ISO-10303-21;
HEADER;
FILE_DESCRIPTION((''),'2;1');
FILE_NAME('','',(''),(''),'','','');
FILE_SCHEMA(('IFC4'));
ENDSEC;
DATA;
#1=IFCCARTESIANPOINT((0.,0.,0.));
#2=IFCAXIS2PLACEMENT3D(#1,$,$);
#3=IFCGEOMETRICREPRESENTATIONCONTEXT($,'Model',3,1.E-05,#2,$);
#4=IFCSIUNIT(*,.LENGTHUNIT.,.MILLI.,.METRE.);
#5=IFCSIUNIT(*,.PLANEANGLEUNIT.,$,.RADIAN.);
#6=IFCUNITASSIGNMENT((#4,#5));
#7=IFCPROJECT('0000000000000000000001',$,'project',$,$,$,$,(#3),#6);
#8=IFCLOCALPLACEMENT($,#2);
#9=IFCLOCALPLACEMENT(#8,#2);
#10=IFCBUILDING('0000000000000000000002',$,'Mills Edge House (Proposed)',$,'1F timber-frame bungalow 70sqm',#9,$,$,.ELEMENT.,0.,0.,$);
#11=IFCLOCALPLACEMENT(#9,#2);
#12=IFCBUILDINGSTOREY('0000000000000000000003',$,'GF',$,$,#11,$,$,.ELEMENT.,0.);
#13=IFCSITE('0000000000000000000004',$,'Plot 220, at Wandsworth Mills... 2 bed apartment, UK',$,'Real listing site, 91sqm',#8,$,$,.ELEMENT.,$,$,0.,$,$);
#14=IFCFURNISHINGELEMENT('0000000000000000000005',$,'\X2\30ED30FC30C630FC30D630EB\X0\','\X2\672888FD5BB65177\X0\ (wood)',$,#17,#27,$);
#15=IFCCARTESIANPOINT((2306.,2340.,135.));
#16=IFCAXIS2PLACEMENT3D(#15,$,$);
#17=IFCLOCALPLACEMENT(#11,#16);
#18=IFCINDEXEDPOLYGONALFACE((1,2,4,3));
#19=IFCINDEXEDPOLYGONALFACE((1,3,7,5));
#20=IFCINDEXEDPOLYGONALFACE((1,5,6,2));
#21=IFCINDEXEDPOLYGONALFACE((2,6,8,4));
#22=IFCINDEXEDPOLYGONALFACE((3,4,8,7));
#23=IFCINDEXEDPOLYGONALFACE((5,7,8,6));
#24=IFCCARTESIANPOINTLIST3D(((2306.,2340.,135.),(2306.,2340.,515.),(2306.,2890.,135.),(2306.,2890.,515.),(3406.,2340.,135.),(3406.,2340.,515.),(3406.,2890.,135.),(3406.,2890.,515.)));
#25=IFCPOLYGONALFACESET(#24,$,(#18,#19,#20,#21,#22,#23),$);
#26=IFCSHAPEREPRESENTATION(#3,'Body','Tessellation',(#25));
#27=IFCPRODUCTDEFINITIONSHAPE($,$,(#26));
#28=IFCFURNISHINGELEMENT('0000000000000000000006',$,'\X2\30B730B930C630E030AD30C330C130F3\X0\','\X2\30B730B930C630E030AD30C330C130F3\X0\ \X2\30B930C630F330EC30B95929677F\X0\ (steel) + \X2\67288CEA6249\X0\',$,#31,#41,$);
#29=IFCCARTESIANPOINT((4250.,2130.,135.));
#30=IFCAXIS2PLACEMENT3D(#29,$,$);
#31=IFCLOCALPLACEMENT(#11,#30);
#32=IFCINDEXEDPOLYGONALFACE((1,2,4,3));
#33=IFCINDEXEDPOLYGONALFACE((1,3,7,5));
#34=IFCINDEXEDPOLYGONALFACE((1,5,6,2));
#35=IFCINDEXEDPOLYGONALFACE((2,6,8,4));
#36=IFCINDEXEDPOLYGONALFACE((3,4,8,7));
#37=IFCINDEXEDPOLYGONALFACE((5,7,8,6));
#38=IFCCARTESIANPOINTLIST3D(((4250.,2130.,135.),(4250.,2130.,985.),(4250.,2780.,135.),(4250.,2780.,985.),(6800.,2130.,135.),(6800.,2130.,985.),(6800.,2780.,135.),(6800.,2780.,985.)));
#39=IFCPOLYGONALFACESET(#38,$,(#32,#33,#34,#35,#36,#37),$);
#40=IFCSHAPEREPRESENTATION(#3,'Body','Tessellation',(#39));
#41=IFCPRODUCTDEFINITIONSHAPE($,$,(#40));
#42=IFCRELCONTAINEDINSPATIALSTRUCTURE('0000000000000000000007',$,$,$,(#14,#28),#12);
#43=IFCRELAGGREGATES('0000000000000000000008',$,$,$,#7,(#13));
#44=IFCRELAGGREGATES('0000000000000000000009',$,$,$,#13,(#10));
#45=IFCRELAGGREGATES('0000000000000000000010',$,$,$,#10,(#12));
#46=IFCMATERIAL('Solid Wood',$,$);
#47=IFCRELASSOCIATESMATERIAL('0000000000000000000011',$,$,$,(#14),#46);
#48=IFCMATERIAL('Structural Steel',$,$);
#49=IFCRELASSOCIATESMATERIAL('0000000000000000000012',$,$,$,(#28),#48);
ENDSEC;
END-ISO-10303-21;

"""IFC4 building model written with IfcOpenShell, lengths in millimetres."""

from ifc_helpers import new_model, si_unit, frame, frame_2d, origin, place, context, project, spatial, rectangle, extrude, material, element, save


model = new_model("IFC4")

# Units and contexts
model_context = context("Model", 3, precision=1e-05, world=origin())
ifc_project = project(units=[si_unit("LENGTHUNIT", "METRE", prefix="MILLI"), si_unit("PLANEANGLEUNIT", "RADIAN")], contexts=[model_context])

# Site, building, storey
site_placement = place(None, origin())
site = spatial("IfcSite", under=ifc_project, at=site_placement, Name="Plot 220, at Wandsworth Mills... 2 bed apartment, UK", ObjectType="Real listing site, 91sqm", CompositionType="ELEMENT", RefElevation=0.0)
building_placement = place(site_placement, origin())
building = spatial("IfcBuilding", under=site, at=building_placement, Name="Mills Edge House (Proposed)", ObjectType="1F timber-frame bungalow 70sqm", CompositionType="ELEMENT", ElevationOfRefHeight=0.0, ElevationOfTerrain=0.0)
storey_placement = place(building_placement, origin())
storey = spatial("IfcBuildingStorey", under=building, at=storey_placement, Name="GF", CompositionType="ELEMENT", Elevation=0.0)

# Shared definitions
ifc_material_1 = material(Name="Solid Wood")

# Furnishing elements
furnishing_1_placement = place(storey_placement, frame((2306.0, 2340.0, 135.0)))
element("IfcFurnishingElement", 1, at=furnishing_1_placement, inside=storey, material=ifc_material_1, Name="ローテーブル", Description="木製家具 (wood)", context=model_context, shape_type="SweptSolid", body=[
    extrude(rectangle(XDim=1100.0, YDim=550.0, at=frame_2d((550.0, 275.0))), frame((2306.0, 2340.0, 135.0)), (0.0, 0.0, 1.0), 380.0),
])
ifc_material_2 = material(Name="Structural Steel")
furnishing_2_placement = place(storey_placement, frame((4250.0, 2130.0, 135.0)))
element("IfcFurnishingElement", 2, at=furnishing_2_placement, inside=storey, material=ifc_material_2, Name="システムキッチン", Description="システムキッチン ステンレス天板 (steel) + 木質扉", context=model_context, shape_type="SweptSolid", body=[
    extrude(rectangle(XDim=2550.0, YDim=650.0, at=frame_2d((1275.0, 325.0))), frame((4250.0, 2130.0, 135.0)), (0.0, 0.0, 1.0), 850.0),
])

save(model, "model.ifc")
